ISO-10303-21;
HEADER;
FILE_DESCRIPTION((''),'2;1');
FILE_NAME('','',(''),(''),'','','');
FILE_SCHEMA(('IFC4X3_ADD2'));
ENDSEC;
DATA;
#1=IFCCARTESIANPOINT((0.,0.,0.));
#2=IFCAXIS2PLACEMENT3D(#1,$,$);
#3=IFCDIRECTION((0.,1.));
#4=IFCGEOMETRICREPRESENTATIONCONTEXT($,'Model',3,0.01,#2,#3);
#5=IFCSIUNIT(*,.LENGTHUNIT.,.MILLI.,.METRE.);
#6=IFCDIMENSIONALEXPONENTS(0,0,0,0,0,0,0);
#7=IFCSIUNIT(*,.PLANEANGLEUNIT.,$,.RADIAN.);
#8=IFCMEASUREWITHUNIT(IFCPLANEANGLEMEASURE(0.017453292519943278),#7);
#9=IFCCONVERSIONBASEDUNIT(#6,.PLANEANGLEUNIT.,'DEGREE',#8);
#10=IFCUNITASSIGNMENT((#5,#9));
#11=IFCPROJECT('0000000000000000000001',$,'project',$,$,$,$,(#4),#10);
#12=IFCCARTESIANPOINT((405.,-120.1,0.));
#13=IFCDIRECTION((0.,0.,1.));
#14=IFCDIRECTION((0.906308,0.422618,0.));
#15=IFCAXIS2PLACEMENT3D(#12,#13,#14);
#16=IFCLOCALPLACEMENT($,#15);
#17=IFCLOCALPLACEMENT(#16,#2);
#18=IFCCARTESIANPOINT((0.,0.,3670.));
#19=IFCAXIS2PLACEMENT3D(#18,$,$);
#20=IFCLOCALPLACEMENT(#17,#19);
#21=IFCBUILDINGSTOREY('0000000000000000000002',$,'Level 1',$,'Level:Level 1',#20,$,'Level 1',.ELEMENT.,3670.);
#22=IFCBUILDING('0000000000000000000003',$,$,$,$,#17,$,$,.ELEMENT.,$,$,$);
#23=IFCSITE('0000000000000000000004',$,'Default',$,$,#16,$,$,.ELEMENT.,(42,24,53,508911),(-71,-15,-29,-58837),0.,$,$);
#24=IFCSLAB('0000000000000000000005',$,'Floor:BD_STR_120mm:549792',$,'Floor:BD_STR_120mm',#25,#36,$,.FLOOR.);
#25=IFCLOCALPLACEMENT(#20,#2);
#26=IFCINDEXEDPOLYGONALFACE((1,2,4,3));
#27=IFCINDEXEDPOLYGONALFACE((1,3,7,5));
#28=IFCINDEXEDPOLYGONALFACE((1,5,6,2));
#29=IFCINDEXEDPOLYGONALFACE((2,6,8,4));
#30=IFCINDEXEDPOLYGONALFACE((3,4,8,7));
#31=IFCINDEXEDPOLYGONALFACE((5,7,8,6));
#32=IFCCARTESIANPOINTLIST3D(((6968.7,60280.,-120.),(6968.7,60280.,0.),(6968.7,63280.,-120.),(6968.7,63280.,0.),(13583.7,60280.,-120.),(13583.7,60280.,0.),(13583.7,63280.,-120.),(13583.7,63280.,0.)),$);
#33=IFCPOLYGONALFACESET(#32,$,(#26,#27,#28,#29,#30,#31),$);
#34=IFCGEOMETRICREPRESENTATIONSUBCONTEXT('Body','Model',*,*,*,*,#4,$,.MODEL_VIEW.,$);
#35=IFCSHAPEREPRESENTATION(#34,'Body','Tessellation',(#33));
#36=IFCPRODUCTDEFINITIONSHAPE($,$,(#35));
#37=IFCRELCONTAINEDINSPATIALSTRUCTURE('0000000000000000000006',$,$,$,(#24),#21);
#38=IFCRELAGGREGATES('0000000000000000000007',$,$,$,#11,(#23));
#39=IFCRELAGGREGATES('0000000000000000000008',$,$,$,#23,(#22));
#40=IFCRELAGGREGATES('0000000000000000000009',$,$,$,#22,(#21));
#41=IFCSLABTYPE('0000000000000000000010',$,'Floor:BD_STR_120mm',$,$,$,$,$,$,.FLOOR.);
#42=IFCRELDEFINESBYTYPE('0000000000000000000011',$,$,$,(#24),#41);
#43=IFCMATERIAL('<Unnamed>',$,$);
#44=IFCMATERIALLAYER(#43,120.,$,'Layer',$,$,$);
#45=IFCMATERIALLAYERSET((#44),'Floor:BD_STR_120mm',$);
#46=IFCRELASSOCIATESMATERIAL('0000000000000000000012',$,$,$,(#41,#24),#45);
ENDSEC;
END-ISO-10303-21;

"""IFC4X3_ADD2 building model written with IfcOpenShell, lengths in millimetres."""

from ifc_helpers import new_model, entity, si_unit, converted_unit, direction, frame, frame_2d, origin, place, context, subcontext, project, spatial, rectangle, extrude, material, layer, layer_set, layer_usage, type_object, element, save


model = new_model("IFC4X3_ADD2")

# Units and contexts
model_context = context("Model", 3, precision=0.01, world=origin(), true_north=direction((0.0, 1.0)))
body_context = subcontext(model_context, "Body", "Model", "MODEL_VIEW")
ifc_project = project(units=[si_unit("LENGTHUNIT", "METRE", prefix="MILLI"), converted_unit("PLANEANGLEUNIT", "DEGREE", entity("IfcPlaneAngleMeasure", 0.017453292519943278), si_unit("PLANEANGLEUNIT", "RADIAN"), dimensions=[0, 0, 0, 0, 0, 0, 0])], contexts=[model_context])

# Site, building, storey
site_placement = place(None, frame((405.0, -120.1, 0.0), z_axis=(0.0, 0.0, 1.0), x_axis=(0.906308, 0.422618, 0.0)))
site = spatial("IfcSite", under=ifc_project, at=site_placement, Name="Default", CompositionType="ELEMENT", RefLatitude=(42, 24, 53, 508911), RefLongitude=(-71, -15, -29, -58837), RefElevation=0.0)
building_placement = place(site_placement, origin())
building = spatial("IfcBuilding", under=site, at=building_placement, CompositionType="ELEMENT")
storey_placement = place(building_placement, frame((0.0, 0.0, 3670.0)))
storey = spatial("IfcBuildingStorey", under=building, at=storey_placement, Name="Level 1", ObjectType="Level:Level 1", LongName="Level 1", CompositionType="ELEMENT", Elevation=3670.0)

# Slab
ifc_material_1 = material(Name="<Unnamed>")
ifc_layer = layer(ifc_material_1, 120.0, Name="Layer")
ifc_layer_set = layer_set([ifc_layer], Name="Floor:BD_STR_120mm")
slab_type = type_object("IfcSlabType", Name="Floor:BD_STR_120mm", PredefinedType="FLOOR", material=ifc_layer_set)
ifc_layer_usage_1 = layer_usage(ifc_layer_set, "AXIS3", "POSITIVE", 0.0)
slab_1_placement = place(storey_placement, origin())
element("IfcSlab", 1, at=slab_1_placement, inside=storey, type_object=slab_type, material=ifc_layer_usage_1, Name="Floor:BD_STR_120mm:549792", ObjectType="Floor:BD_STR_120mm", PredefinedType="FLOOR", context=body_context, shape_type="SweptSolid", body=[
    extrude(rectangle(XDim=3000.0, YDim=6615.0, at=frame_2d((0.0, 0.0), x_axis=(1.0, 0.0))), frame((10276.2, 61780.0, 0.0), z_axis=(0.0, 0.0, -1.0), x_axis=(0.0, 1.0, 0.0)), (0.0, 0.0, 1.0), 120.0),
])

save(model, "model.ifc")
